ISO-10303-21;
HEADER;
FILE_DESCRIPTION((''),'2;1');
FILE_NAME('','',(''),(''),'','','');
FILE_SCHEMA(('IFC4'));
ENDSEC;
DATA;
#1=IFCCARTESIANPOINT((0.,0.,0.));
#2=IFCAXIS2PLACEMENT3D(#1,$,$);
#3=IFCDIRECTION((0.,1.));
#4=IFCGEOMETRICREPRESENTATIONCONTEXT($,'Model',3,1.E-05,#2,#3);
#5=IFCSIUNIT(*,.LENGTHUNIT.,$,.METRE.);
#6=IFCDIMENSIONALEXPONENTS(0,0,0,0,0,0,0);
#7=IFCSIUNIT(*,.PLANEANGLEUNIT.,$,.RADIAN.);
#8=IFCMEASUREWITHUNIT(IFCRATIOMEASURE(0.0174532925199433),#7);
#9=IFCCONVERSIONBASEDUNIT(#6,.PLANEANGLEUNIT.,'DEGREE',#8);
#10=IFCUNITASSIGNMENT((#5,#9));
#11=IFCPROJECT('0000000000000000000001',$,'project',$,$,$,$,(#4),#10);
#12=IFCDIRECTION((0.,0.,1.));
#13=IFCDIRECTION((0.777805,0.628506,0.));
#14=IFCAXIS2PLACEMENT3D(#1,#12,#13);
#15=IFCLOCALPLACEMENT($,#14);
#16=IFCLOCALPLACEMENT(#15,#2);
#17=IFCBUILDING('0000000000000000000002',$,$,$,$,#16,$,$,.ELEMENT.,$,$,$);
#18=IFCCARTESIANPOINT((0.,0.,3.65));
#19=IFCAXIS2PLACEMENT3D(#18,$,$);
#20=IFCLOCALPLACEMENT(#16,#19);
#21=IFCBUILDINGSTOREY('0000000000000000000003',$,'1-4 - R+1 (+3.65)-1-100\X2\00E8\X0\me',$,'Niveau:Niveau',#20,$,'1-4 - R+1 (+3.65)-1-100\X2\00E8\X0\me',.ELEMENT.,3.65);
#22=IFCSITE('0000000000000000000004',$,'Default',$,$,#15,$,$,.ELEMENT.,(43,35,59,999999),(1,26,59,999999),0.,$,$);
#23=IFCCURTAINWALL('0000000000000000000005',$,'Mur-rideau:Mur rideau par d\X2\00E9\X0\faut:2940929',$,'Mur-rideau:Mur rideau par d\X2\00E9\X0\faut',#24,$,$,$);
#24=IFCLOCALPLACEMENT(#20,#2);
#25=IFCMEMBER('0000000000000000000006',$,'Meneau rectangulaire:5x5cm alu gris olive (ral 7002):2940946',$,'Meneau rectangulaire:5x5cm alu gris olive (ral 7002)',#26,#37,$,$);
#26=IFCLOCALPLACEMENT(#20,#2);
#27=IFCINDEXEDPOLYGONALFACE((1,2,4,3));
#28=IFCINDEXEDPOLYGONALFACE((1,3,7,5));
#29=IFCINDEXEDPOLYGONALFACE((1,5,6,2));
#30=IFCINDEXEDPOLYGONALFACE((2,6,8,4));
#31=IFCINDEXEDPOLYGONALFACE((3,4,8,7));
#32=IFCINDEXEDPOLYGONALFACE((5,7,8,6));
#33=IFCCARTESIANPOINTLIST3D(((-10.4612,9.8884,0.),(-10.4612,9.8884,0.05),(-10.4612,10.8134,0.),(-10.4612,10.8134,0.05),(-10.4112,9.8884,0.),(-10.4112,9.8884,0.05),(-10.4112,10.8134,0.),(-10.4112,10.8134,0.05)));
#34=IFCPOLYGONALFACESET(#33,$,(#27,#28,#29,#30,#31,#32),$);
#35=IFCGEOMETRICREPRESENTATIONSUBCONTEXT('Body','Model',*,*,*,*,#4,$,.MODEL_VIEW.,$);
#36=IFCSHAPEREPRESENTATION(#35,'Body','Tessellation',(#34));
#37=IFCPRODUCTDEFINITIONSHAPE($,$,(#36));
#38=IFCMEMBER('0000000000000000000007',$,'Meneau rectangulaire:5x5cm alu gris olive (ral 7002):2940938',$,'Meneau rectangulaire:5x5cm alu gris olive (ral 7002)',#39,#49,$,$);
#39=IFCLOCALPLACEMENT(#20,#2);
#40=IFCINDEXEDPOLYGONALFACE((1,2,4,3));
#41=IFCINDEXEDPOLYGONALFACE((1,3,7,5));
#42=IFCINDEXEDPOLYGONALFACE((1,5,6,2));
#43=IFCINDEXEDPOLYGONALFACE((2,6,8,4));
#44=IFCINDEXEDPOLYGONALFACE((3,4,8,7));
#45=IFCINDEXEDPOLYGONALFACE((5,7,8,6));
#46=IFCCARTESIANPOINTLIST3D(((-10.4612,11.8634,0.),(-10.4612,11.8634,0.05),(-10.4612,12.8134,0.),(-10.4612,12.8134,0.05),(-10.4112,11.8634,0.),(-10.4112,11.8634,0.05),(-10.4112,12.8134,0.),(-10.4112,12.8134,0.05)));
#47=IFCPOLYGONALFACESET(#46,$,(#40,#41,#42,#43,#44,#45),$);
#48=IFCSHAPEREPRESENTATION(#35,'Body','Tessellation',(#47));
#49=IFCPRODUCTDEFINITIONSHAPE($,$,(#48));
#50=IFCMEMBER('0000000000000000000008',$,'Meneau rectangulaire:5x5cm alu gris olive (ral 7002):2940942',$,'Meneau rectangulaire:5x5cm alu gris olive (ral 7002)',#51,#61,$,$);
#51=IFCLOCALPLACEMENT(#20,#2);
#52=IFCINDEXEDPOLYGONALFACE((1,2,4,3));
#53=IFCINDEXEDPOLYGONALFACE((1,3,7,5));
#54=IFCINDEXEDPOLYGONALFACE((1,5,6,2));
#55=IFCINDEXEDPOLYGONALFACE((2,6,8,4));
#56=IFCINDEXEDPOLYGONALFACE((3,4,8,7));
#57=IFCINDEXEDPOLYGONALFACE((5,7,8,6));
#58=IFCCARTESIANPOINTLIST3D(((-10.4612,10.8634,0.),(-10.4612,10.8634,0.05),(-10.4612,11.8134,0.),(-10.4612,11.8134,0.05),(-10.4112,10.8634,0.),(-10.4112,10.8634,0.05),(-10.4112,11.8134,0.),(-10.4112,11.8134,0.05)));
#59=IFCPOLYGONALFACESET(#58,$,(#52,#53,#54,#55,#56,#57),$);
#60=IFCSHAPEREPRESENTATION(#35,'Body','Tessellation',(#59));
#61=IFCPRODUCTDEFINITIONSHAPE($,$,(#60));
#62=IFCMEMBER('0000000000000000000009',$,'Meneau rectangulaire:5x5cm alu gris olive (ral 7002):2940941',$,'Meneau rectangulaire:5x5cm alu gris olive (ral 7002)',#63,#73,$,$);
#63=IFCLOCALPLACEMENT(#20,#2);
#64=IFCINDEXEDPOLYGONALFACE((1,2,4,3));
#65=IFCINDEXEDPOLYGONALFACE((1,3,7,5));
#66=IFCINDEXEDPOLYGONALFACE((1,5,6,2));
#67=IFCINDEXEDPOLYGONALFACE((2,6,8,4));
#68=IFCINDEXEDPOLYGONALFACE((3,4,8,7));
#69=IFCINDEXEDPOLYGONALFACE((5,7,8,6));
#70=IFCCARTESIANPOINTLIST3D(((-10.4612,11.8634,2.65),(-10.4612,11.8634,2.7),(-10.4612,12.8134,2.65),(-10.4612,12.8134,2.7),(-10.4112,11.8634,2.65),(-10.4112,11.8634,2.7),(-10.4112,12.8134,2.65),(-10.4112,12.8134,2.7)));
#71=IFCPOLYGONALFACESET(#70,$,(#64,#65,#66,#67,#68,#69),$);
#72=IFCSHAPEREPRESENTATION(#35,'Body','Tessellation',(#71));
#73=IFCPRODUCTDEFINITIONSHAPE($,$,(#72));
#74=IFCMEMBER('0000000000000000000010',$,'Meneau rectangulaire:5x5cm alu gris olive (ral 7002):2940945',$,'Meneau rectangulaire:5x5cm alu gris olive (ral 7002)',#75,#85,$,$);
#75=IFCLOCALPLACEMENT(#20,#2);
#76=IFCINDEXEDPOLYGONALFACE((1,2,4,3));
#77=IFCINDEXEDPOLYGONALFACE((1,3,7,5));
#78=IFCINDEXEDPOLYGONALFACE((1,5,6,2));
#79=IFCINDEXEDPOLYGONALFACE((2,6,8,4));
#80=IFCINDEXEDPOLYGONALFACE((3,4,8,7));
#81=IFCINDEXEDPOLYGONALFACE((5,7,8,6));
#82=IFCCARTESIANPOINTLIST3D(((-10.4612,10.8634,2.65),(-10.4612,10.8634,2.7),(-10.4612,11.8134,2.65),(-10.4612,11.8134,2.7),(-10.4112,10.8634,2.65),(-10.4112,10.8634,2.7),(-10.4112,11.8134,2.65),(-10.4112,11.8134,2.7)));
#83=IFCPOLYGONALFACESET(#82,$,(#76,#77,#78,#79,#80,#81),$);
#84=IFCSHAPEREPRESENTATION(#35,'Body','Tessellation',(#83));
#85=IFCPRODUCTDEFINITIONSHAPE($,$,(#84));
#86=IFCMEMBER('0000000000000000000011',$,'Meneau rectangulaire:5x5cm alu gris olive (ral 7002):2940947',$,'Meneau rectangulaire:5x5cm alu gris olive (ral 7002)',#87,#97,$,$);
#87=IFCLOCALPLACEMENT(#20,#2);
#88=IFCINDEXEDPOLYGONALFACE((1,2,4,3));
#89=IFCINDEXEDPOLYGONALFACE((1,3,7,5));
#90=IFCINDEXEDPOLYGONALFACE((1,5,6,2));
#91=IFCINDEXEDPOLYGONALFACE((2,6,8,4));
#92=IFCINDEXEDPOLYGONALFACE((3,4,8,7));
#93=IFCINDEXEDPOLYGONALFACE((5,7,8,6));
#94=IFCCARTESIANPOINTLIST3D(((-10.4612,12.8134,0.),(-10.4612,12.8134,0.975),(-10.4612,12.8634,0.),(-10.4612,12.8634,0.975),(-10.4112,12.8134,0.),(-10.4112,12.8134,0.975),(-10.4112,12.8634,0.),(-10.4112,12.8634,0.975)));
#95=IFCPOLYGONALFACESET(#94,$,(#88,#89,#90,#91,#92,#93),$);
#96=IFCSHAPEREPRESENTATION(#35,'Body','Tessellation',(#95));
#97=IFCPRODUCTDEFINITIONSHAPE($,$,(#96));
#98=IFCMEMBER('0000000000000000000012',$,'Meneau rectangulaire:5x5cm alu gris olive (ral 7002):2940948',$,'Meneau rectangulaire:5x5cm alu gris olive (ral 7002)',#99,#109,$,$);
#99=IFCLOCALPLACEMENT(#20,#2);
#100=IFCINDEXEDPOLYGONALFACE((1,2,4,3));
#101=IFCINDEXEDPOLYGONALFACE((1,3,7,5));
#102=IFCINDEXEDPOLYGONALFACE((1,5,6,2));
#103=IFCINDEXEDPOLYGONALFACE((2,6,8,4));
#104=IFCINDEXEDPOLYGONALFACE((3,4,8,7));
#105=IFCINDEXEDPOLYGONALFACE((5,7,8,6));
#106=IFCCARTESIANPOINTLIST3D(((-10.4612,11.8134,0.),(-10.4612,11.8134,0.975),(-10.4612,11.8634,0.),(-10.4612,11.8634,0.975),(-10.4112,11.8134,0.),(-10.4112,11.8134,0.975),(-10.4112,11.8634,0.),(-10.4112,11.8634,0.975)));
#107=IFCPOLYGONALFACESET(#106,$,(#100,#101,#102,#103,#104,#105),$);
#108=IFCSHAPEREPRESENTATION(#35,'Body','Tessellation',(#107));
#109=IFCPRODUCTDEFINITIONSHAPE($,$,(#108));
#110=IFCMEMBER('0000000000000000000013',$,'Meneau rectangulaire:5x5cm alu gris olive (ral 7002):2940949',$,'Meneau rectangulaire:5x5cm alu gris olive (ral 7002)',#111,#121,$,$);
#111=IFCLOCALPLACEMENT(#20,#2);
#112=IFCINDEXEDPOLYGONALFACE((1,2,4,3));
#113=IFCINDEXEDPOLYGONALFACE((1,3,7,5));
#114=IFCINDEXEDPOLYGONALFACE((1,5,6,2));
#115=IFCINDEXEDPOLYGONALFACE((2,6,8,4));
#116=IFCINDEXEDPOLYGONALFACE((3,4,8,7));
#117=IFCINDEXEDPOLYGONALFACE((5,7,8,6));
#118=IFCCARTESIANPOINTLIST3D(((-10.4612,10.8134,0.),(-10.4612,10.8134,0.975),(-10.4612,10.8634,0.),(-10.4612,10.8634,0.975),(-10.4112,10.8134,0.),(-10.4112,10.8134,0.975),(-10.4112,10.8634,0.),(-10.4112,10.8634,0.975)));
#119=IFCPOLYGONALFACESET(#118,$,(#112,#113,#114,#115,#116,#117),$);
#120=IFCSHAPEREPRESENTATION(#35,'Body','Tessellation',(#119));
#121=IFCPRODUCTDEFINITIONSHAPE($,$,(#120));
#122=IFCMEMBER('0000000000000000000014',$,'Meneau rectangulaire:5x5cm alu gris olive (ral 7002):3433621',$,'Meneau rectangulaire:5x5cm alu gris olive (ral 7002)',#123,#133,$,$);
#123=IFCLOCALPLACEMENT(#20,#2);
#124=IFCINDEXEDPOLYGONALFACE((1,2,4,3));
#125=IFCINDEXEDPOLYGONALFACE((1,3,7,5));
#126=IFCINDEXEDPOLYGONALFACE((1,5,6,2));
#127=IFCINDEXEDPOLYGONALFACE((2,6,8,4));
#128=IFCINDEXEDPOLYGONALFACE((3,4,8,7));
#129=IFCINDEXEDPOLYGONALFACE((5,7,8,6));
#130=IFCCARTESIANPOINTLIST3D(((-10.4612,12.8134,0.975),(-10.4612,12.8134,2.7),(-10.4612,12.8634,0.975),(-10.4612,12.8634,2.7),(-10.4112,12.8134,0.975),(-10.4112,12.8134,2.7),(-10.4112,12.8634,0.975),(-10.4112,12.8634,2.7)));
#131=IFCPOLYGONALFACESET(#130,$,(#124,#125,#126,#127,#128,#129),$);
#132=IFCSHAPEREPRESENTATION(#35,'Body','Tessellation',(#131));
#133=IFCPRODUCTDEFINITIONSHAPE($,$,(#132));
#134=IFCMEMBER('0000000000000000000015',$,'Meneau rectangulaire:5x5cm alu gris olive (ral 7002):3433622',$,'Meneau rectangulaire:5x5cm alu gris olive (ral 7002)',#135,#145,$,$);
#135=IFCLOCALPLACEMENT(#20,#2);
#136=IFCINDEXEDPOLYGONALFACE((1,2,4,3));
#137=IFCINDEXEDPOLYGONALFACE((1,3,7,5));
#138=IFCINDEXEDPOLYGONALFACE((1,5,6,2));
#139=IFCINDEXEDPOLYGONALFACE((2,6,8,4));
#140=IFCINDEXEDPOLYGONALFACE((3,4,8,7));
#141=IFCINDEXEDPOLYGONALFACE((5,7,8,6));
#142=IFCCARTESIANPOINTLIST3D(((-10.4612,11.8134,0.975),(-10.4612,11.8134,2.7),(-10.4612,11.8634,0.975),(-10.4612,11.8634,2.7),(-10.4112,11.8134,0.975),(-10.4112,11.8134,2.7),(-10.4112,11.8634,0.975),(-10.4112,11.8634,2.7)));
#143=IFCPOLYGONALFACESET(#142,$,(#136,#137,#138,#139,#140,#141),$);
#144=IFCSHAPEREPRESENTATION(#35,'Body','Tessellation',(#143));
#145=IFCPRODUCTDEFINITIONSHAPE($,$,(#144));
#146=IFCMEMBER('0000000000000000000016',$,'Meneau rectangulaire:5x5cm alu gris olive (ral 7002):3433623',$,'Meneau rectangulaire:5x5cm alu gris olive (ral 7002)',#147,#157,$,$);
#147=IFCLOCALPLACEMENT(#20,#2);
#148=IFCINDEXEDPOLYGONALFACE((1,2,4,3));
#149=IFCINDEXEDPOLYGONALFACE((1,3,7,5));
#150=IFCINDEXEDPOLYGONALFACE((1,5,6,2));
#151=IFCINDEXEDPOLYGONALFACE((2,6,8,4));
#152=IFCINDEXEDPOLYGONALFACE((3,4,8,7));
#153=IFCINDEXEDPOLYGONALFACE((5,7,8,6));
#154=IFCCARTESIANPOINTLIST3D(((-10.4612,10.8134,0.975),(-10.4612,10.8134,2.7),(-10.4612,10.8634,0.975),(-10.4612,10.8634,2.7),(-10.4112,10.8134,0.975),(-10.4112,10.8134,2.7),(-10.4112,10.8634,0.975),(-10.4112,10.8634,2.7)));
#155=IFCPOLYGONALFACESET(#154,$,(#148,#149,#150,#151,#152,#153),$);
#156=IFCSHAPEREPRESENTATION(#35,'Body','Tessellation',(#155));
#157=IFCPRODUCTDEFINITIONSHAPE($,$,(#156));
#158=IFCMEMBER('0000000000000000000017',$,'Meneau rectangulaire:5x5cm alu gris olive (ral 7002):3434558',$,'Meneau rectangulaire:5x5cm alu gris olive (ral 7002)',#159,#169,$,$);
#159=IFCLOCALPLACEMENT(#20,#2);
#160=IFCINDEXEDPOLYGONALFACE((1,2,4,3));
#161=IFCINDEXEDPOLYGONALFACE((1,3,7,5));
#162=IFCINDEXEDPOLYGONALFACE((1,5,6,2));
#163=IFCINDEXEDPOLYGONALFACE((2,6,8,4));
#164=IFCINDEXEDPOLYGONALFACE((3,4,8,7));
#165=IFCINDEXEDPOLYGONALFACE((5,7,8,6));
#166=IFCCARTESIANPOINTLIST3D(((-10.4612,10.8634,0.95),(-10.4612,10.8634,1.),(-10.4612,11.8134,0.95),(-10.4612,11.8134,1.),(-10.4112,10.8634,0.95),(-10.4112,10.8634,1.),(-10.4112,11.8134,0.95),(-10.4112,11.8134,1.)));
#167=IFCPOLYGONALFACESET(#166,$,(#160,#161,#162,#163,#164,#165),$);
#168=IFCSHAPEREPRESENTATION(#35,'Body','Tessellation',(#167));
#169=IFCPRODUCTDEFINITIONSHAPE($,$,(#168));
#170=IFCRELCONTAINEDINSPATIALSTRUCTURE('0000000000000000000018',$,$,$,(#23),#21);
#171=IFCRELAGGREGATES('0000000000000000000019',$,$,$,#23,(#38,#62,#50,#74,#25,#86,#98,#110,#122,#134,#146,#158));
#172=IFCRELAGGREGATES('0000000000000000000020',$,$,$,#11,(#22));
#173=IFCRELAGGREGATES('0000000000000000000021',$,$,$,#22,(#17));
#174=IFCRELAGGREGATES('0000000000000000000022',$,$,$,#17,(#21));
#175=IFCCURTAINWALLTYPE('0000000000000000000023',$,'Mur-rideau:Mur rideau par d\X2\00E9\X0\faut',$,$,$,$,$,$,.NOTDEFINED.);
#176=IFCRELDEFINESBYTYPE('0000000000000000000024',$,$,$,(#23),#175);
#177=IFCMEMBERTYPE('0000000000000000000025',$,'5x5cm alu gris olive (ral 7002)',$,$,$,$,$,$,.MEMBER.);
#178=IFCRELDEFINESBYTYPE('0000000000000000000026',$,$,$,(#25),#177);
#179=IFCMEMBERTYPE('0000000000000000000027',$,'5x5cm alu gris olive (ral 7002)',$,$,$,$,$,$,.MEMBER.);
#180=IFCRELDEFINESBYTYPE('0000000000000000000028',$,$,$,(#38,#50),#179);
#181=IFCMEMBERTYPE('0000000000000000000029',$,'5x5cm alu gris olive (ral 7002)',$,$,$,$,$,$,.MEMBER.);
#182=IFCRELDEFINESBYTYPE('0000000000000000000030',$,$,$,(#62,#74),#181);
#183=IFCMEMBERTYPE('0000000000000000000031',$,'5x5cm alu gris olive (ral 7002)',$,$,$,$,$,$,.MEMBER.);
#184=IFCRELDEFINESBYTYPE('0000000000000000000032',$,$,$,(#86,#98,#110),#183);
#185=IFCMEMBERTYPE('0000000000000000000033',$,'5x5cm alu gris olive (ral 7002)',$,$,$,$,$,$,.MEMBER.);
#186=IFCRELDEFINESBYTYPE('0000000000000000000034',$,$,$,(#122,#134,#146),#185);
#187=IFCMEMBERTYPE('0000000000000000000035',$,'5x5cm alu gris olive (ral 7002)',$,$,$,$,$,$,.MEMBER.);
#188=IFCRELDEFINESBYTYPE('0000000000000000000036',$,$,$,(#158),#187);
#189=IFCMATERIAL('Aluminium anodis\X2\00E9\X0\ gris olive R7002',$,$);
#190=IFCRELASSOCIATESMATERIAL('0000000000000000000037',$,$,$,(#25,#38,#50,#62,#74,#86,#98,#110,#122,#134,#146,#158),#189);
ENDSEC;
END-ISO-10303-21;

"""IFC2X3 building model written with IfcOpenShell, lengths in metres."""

from ifc_helpers import new_model, entity, si_unit, converted_unit, direction, frame, origin, origin_2d_with_axis, place, context, subcontext, project, spatial, rectangle, extrude, source, transform, mapped, material, type_object, type_shapes, element, aggregate, save


model = new_model("IFC2X3")

# Units and contexts
model_context = context("Model", 3, precision=1e-05, world=origin(), true_north=direction((0.0, 1.0)))
body_context = subcontext(model_context, "Body", "Model", "MODEL_VIEW")
ifc_project = project(units=[si_unit("LENGTHUNIT", "METRE"), converted_unit("PLANEANGLEUNIT", "DEGREE", entity("IfcRatioMeasure", 0.0174532925199433), si_unit("PLANEANGLEUNIT", "RADIAN"), dimensions=[0, 0, 0, 0, 0, 0, 0])], contexts=[model_context])

# Site, building, storey
site_placement = place(None, frame((0.0, 0.0, 0.0), z_axis=(0.0, 0.0, 1.0), x_axis=(0.777805, 0.628506, 0.0)))
site = spatial("IfcSite", under=ifc_project, at=site_placement, Name="Default", CompositionType="ELEMENT", RefLatitude=(43, 35, 59, 999999), RefLongitude=(1, 26, 59, 999999), RefElevation=0.0)
building_placement = place(site_placement, origin())
building = spatial("IfcBuilding", under=site, at=building_placement, CompositionType="ELEMENT")
storey_placement = place(building_placement, frame((0.0, 0.0, 3.65)))
storey = spatial("IfcBuildingStorey", under=building, at=storey_placement, Name="1-4 - R+1 (+3.65)-1-100ème", ObjectType="Niveau:Niveau", LongName="1-4 - R+1 (+3.65)-1-100ème", CompositionType="ELEMENT", Elevation=3.65)

# Curtain wall, members
curtain_wall_type = type_object("IfcCurtainWallType", Name="Mur-rideau:Mur rideau par défaut", PredefinedType="NOTDEFINED")
curtain_wall_placement = place(storey_placement, frame((0.0, 0.0, -3.65)))
curtain_wall = element("IfcCurtainWall", 1, at=curtain_wall_placement, inside=storey, type_object=curtain_wall_type, Name="Mur-rideau:Mur rideau par défaut:2940929", ObjectType="Mur-rideau:Mur rideau par défaut")
ifc_material_1 = material(Name="Aluminium anodisé gris olive R7002")
member_type_1 = type_object("IfcMemberType", Name="5x5cm alu gris olive (ral 7002)", PredefinedType="MEMBER")
shared_shape_1 = source(origin(), body_context, "Body", "SweptSolid", [
    extrude(rectangle(XDim=0.05, YDim=0.05, at=origin_2d_with_axis()), frame((-0.025, 0.0, -0.925), z_axis=(0.0, 0.0, 1.0), x_axis=(0.0, -1.0, 0.0)), (0.0, 0.0, 1.0), 0.925),
])
type_shapes(member_type_1, [shared_shape_1])
member_1_placement = place(storey_placement, frame((-10.4362, 10.8134, 0.0), z_axis=(0.0, 1.0, 0.0), x_axis=(0.0, 0.0, -1.0)))
member_1 = element("IfcMember", 2, at=member_1_placement, type_object=member_type_1, material=ifc_material_1, Name="Meneau rectangulaire:5x5cm alu gris olive (ral 7002):2940946", ObjectType="Meneau rectangulaire:5x5cm alu gris olive (ral 7002)", context=body_context, shape_type="MappedRepresentation", body=[
    mapped(shared_shape_1, transform((0.0, 0.0, 0.0), scale=1.0)),
])
member_type_2 = type_object("IfcMemberType", Name="5x5cm alu gris olive (ral 7002)", PredefinedType="MEMBER")
shared_shape_2 = source(origin(), body_context, "Body", "SweptSolid", [
    extrude(rectangle(XDim=0.05, YDim=0.05, at=origin_2d_with_axis()), frame((-0.025, 0.0, -0.95), z_axis=(0.0, 0.0, 1.0), x_axis=(0.0, -1.0, 0.0)), (0.0, 0.0, 1.0), 0.95),
])
type_shapes(member_type_2, [shared_shape_2])
member_2_placement = place(storey_placement, frame((-10.4362, 12.8134, 0.0), z_axis=(0.0, 1.0, 0.0), x_axis=(0.0, 0.0, -1.0)))
member_2 = element("IfcMember", 3, at=member_2_placement, type_object=member_type_2, material=ifc_material_1, Name="Meneau rectangulaire:5x5cm alu gris olive (ral 7002):2940938", ObjectType="Meneau rectangulaire:5x5cm alu gris olive (ral 7002)", context=body_context, shape_type="MappedRepresentation", body=[
    mapped(shared_shape_2, transform((0.0, 0.0, 0.0), scale=1.0)),
])
member_3_placement = place(storey_placement, frame((-10.4362, 11.8134, 0.0), z_axis=(0.0, 1.0, 0.0), x_axis=(0.0, 0.0, -1.0)))
member_3 = element("IfcMember", 4, at=member_3_placement, type_object=member_type_2, material=ifc_material_1, Name="Meneau rectangulaire:5x5cm alu gris olive (ral 7002):2940942", ObjectType="Meneau rectangulaire:5x5cm alu gris olive (ral 7002)", context=body_context, shape_type="MappedRepresentation", body=[
    mapped(shared_shape_2, transform((0.0, 0.0, 0.0), scale=1.0)),
])
member_type_3 = type_object("IfcMemberType", Name="5x5cm alu gris olive (ral 7002)", PredefinedType="MEMBER")
shared_shape_3 = source(origin(), body_context, "Body", "SweptSolid", [
    extrude(rectangle(XDim=0.05, YDim=0.05, at=origin_2d_with_axis()), frame((-0.025, 0.0, -0.95), z_axis=(0.0, 0.0, 1.0), x_axis=(0.0, -1.0, 0.0)), (0.0, 0.0, 1.0), 0.95),
])
type_shapes(member_type_3, [shared_shape_3])
member_4_placement = place(storey_placement, frame((-10.4362, 11.8634, 2.7), z_axis=(0.0, -1.0, 0.0), x_axis=(0.0, 0.0, 1.0)))
member_4 = element("IfcMember", 5, at=member_4_placement, type_object=member_type_3, material=ifc_material_1, Name="Meneau rectangulaire:5x5cm alu gris olive (ral 7002):2940941", ObjectType="Meneau rectangulaire:5x5cm alu gris olive (ral 7002)", context=body_context, shape_type="MappedRepresentation", body=[
    mapped(shared_shape_3, transform((0.0, 0.0, 0.0), scale=1.0)),
])
member_5_placement = place(storey_placement, frame((-10.4362, 10.8634, 2.7), z_axis=(0.0, -1.0, 0.0), x_axis=(0.0, 0.0, 1.0)))
member_5 = element("IfcMember", 6, at=member_5_placement, type_object=member_type_3, material=ifc_material_1, Name="Meneau rectangulaire:5x5cm alu gris olive (ral 7002):2940945", ObjectType="Meneau rectangulaire:5x5cm alu gris olive (ral 7002)", context=body_context, shape_type="MappedRepresentation", body=[
    mapped(shared_shape_3, transform((0.0, 0.0, 0.0), scale=1.0)),
])
member_type_4 = type_object("IfcMemberType", Name="5x5cm alu gris olive (ral 7002)", PredefinedType="MEMBER")
shared_shape_4 = source(origin(), body_context, "Body", "SweptSolid", [
    extrude(rectangle(XDim=0.05, YDim=0.05, at=origin_2d_with_axis()), frame((0.0, 0.0, -0.975), z_axis=(0.0, 0.0, 1.0), x_axis=(0.0, -1.0, 0.0)), (0.0, 0.0, 1.0), 0.975),
])
type_shapes(member_type_4, [shared_shape_4])
member_6_placement = place(storey_placement, frame((-10.4362, 12.8384, 0.0), z_axis=(0.0, 0.0, -1.0), x_axis=(0.0, -1.0, 0.0)))
member_6 = element("IfcMember", 7, at=member_6_placement, type_object=member_type_4, material=ifc_material_1, Name="Meneau rectangulaire:5x5cm alu gris olive (ral 7002):2940947", ObjectType="Meneau rectangulaire:5x5cm alu gris olive (ral 7002)", context=body_context, shape_type="MappedRepresentation", body=[
    mapped(shared_shape_4, transform((0.0, 0.0, 0.0), scale=1.0)),
])
member_7_placement = place(storey_placement, frame((-10.4362, 11.8384, 0.0), z_axis=(0.0, 0.0, -1.0), x_axis=(0.0, -1.0, 0.0)))
member_7 = element("IfcMember", 8, at=member_7_placement, type_object=member_type_4, material=ifc_material_1, Name="Meneau rectangulaire:5x5cm alu gris olive (ral 7002):2940948", ObjectType="Meneau rectangulaire:5x5cm alu gris olive (ral 7002)", context=body_context, shape_type="MappedRepresentation", body=[
    mapped(shared_shape_4, transform((0.0, 0.0, 0.0), scale=1.0)),
])
member_8_placement = place(storey_placement, frame((-10.4362, 10.8384, 0.0), z_axis=(0.0, 0.0, -1.0), x_axis=(0.0, -1.0, 0.0)))
member_8 = element("IfcMember", 9, at=member_8_placement, type_object=member_type_4, material=ifc_material_1, Name="Meneau rectangulaire:5x5cm alu gris olive (ral 7002):2940949", ObjectType="Meneau rectangulaire:5x5cm alu gris olive (ral 7002)", context=body_context, shape_type="MappedRepresentation", body=[
    mapped(shared_shape_4, transform((0.0, 0.0, 0.0), scale=1.0)),
])
member_type_5 = type_object("IfcMemberType", Name="5x5cm alu gris olive (ral 7002)", PredefinedType="MEMBER")
shared_shape_5 = source(origin(), body_context, "Body", "SweptSolid", [
    extrude(rectangle(XDim=0.05, YDim=0.05, at=origin_2d_with_axis()), frame((0.0, 0.0, -1.725), z_axis=(0.0, 0.0, 1.0), x_axis=(0.0, -1.0, 0.0)), (0.0, 0.0, 1.0), 1.725),
])
type_shapes(member_type_5, [shared_shape_5])
member_9_placement = place(storey_placement, frame((-10.4362, 12.8384, 0.975), z_axis=(0.0, 0.0, -1.0), x_axis=(0.0, -1.0, 0.0)))
member_9 = element("IfcMember", 10, at=member_9_placement, type_object=member_type_5, material=ifc_material_1, Name="Meneau rectangulaire:5x5cm alu gris olive (ral 7002):3433621", ObjectType="Meneau rectangulaire:5x5cm alu gris olive (ral 7002)", context=body_context, shape_type="MappedRepresentation", body=[
    mapped(shared_shape_5, transform((0.0, 0.0, 0.0), scale=1.0)),
])
member_10_placement = place(storey_placement, frame((-10.4362, 11.8384, 0.975), z_axis=(0.0, 0.0, -1.0), x_axis=(0.0, -1.0, 0.0)))
member_10 = element("IfcMember", 11, at=member_10_placement, type_object=member_type_5, material=ifc_material_1, Name="Meneau rectangulaire:5x5cm alu gris olive (ral 7002):3433622", ObjectType="Meneau rectangulaire:5x5cm alu gris olive (ral 7002)", context=body_context, shape_type="MappedRepresentation", body=[
    mapped(shared_shape_5, transform((0.0, 0.0, 0.0), scale=1.0)),
])
member_11_placement = place(storey_placement, frame((-10.4362, 10.8384, 0.975), z_axis=(0.0, 0.0, -1.0), x_axis=(0.0, -1.0, 0.0)))
member_11 = element("IfcMember", 12, at=member_11_placement, type_object=member_type_5, material=ifc_material_1, Name="Meneau rectangulaire:5x5cm alu gris olive (ral 7002):3433623", ObjectType="Meneau rectangulaire:5x5cm alu gris olive (ral 7002)", context=body_context, shape_type="MappedRepresentation", body=[
    mapped(shared_shape_5, transform((0.0, 0.0, 0.0), scale=1.0)),
])
member_type_6 = type_object("IfcMemberType", Name="5x5cm alu gris olive (ral 7002)", PredefinedType="MEMBER")
shared_shape_6 = source(origin(), body_context, "Body", "SweptSolid", [
    extrude(rectangle(XDim=0.05, YDim=0.05, at=origin_2d_with_axis()), frame((0.0, 0.0, -0.95), z_axis=(0.0, 0.0, 1.0), x_axis=(0.0, -1.0, 0.0)), (0.0, 0.0, 1.0), 0.95),
])
type_shapes(member_type_6, [shared_shape_6])
member_12_placement = place(storey_placement, frame((-10.4362, 10.8634, 0.975), z_axis=(0.0, -1.0, 0.0), x_axis=(0.0, 0.0, 1.0)))
member_12 = element("IfcMember", 13, at=member_12_placement, type_object=member_type_6, material=ifc_material_1, Name="Meneau rectangulaire:5x5cm alu gris olive (ral 7002):3434558", ObjectType="Meneau rectangulaire:5x5cm alu gris olive (ral 7002)", context=body_context, shape_type="MappedRepresentation", body=[
    mapped(shared_shape_6, transform((0.0, 0.0, 0.0), scale=1.0)),
])
aggregate(curtain_wall, [member_2, member_4, member_3, member_5, member_1, member_6, member_7, member_8, member_9, member_10, member_11, member_12])

save(model, "model.ifc")
